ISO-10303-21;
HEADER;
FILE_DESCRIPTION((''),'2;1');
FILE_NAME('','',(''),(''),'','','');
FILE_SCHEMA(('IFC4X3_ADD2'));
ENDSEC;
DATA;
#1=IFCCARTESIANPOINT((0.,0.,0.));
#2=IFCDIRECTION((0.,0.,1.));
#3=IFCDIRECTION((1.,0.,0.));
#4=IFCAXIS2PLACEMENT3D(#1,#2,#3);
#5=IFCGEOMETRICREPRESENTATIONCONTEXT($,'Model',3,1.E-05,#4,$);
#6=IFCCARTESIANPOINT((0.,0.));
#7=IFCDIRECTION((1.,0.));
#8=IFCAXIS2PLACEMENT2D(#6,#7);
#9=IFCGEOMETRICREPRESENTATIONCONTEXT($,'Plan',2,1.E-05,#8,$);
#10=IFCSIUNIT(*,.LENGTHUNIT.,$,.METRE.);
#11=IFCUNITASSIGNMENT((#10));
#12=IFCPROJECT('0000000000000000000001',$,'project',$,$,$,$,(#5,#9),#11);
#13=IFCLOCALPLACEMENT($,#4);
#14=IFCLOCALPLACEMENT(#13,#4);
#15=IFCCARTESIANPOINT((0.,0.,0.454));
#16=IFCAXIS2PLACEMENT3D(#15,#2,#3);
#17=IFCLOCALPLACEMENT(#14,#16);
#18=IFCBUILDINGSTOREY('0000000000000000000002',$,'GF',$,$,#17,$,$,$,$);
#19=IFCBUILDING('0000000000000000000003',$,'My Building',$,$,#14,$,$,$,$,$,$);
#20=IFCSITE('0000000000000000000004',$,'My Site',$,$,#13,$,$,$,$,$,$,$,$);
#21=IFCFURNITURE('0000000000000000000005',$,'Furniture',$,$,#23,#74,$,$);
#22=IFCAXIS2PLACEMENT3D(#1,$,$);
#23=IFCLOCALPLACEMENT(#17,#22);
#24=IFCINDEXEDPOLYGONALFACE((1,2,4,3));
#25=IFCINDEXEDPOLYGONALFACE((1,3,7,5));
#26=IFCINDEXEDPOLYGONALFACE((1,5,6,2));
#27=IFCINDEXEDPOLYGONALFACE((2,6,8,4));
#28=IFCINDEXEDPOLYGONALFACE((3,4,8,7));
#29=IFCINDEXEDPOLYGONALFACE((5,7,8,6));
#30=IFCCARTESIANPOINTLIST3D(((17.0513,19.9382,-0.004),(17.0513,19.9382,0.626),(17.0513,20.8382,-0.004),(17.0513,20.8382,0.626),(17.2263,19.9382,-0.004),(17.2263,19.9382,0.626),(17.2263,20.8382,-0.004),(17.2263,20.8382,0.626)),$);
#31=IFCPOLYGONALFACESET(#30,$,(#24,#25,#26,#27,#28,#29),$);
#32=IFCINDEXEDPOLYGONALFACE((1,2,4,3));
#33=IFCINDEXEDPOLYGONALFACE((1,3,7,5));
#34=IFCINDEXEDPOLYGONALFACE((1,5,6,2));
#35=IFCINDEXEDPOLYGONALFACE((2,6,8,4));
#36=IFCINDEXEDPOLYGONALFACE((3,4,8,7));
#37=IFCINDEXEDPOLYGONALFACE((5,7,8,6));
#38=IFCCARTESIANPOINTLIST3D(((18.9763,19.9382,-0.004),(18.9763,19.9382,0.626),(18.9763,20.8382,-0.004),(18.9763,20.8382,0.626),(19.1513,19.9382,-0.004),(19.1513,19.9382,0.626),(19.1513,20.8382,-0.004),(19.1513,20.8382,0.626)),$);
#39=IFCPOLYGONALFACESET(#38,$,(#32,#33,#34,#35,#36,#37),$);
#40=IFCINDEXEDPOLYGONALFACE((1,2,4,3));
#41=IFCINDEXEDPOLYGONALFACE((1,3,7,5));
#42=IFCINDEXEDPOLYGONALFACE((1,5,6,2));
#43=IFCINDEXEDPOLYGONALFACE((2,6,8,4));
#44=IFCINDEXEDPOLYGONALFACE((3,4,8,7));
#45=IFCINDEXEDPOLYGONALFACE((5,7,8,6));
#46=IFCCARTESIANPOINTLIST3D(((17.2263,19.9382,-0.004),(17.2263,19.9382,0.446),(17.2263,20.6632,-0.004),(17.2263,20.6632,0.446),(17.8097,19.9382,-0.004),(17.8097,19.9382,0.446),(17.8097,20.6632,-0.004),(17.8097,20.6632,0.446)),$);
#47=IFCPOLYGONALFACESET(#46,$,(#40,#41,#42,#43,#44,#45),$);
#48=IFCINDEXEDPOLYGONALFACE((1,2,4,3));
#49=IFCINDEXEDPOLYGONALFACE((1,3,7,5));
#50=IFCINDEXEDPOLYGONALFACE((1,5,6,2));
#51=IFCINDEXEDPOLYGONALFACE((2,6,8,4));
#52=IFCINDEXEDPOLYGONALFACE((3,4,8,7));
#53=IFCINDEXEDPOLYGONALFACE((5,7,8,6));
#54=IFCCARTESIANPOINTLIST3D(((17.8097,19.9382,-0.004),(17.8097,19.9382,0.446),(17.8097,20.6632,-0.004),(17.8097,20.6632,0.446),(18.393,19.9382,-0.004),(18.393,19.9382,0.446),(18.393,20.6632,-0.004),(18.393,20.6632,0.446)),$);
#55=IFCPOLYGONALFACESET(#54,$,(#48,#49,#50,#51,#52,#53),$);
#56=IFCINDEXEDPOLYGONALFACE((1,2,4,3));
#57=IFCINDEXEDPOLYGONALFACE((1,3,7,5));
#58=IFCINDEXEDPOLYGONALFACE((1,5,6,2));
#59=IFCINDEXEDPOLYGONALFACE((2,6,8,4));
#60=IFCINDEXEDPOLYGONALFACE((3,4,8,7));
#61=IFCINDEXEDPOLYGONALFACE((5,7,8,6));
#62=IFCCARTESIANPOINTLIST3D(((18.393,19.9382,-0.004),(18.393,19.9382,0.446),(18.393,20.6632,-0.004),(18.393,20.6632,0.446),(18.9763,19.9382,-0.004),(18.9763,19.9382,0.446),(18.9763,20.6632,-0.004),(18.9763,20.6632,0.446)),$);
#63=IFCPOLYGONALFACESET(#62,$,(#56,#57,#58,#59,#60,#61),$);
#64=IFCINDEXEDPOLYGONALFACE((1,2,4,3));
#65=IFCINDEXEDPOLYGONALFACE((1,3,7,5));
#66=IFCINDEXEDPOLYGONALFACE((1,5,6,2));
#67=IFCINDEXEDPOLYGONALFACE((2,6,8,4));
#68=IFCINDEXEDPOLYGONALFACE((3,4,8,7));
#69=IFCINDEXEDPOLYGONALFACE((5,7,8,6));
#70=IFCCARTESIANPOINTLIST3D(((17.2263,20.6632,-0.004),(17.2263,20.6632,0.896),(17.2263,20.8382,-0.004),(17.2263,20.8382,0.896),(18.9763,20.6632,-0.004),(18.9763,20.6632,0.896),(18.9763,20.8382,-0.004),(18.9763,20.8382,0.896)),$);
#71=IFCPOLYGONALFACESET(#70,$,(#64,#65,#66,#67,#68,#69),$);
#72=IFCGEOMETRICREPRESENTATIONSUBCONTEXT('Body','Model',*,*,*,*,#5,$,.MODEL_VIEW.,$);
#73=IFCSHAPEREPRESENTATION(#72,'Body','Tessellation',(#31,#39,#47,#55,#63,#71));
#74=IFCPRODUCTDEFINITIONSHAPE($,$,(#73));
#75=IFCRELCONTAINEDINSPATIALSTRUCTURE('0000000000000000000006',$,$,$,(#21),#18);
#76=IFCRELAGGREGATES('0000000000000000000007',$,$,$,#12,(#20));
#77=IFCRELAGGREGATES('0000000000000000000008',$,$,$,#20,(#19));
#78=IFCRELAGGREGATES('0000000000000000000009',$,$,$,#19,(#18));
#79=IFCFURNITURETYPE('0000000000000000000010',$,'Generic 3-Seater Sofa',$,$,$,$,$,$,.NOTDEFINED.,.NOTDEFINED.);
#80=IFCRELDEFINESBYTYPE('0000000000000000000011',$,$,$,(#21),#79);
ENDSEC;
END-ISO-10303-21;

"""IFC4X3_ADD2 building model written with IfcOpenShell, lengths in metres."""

from ifc_helpers import new_model, entity, si_unit, frame, origin_with_axes, origin_2d_with_axis, place, context, subcontext, project, spatial, line, indexed_curve, outline, extrude, shape, source, transform, mapped, type_object, type_shapes, element, save


model = new_model("IFC4X3_ADD2")

# Units and contexts
model_context = context("Model", 3, precision=1e-05, world=origin_with_axes())
plan_context = context("Plan", 2, precision=1e-05, world=origin_2d_with_axis())
body_context_1 = subcontext(model_context, "Body", "Model", "MODEL_VIEW")
body_context_2 = subcontext(plan_context, "Body", "Plan", "PLAN_VIEW")
ifc_project = project(units=[si_unit("LENGTHUNIT", "METRE")], contexts=[model_context, plan_context])

# Site, building, storey
site_placement = place(None, origin_with_axes())
site = spatial("IfcSite", under=ifc_project, at=site_placement, Name="My Site")
building_placement = place(site_placement, origin_with_axes())
building = spatial("IfcBuilding", under=site, at=building_placement, Name="My Building")
storey_placement = place(building_placement, frame((0.0, 0.0, 0.454), z_axis=(0.0, 0.0, 1.0), x_axis=(1.0, 0.0, 0.0)))
storey = spatial("IfcBuildingStorey", under=building, at=storey_placement, Name="GF")

# Furniture
furniture_type_1 = type_object("IfcFurnitureType", Name="Generic 3-Seater Sofa", AssemblyPlace="NOTDEFINED", PredefinedType="NOTDEFINED")
shared_shape_1 = source(origin_with_axes(), body_context_1, "Body", "SweptSolid", [
    extrude(outline(indexed_curve([(0.0, 0.0), (0.175, 0.0), (0.175, 0.9), (0.0, 0.9)], segments=[line(4, 1), line(1, 2), line(2, 3), line(3, 4)], self_intersect=False)), frame((-1.05, -0.9, 0.0), z_axis=(0.0, 0.0, 1.0), x_axis=(1.0, 0.0, 0.0)), (0.0, 0.0, 1.0), 0.63),
    extrude(outline(indexed_curve([(0.0, 0.0), (0.175, 0.0), (0.175, 0.9), (0.0, 0.9)], segments=[line(1, 2, 3, 4, 1)])), frame((0.875, -0.9, 0.0), z_axis=(0.0, 0.0, 1.0), x_axis=(1.0, 0.0, 0.0)), (0.0, 0.0, 1.0), 0.63),
    extrude(outline(indexed_curve([(0.175, 0.0), (0.7583, 0.0), (0.7583, 0.725), (0.175, 0.725)], segments=[line(1, 2, 3, 4, 1)])), frame((-1.05, -0.9, 0.0), z_axis=(0.0, 0.0, 1.0), x_axis=(1.0, 0.0, 0.0)), (0.0, 0.0, 1.0), 0.45),
    extrude(outline(indexed_curve([(0.7583, 0.0), (1.3417, 0.0), (1.3417, 0.725), (0.7583, 0.725)], segments=[line(1, 2, 3, 4, 1)])), frame((-1.05, -0.9, 0.0), z_axis=(0.0, 0.0, 1.0), x_axis=(1.0, 0.0, 0.0)), (0.0, 0.0, 1.0), 0.45),
    extrude(outline(indexed_curve([(1.3417, 0.0), (1.925, 0.0), (1.925, 0.725), (1.3417, 0.725)], segments=[line(1, 2, 3, 4, 1)])), frame((-1.05, -0.9, 0.0), z_axis=(0.0, 0.0, 1.0), x_axis=(1.0, 0.0, 0.0)), (0.0, 0.0, 1.0), 0.45),
    extrude(outline(indexed_curve([(0.175, 0.725), (1.925, 0.725), (1.925, 0.9), (0.175, 0.9)], segments=[line(1, 2, 3, 4, 1)])), frame((-1.05, -0.9, 0.0), z_axis=(0.0, 0.0, 1.0), x_axis=(1.0, 0.0, 0.0)), (0.0, 0.0, 1.0), 0.9),
])
shared_shape_2 = source(origin_with_axes(), body_context_2, "Body", "Annotation2D", [
    entity("IfcGeometricCurveSet", [entity("IfcIndexedPolyCurve", entity("IfcCartesianPointList2D", [[0.2917, -0.175], [0.2917, -0.9], [0.875, -0.9], [0.875, -0.175], [-0.875, -0.175], [-0.875, 0.0], [0.875, 0.0], [1.05, 0.0], [1.05, -0.9], [0.875, -0.9], [0.875, 0.0], [0.875, -0.175], [0.2917, -0.175], [-0.2917, -0.175], [-0.2917, -0.9], [-0.875, -0.9], [-0.875, 0.0], [-1.05, 0.0], [-1.05, -0.9], [-0.875, -0.9], [-0.875, -0.175], [-0.2917, -0.175]])), entity("IfcIndexedPolyCurve", entity("IfcCartesianPointList2D", [[0.2917, -0.9], [-0.2917, -0.9]]))]),
])
type_shapes(furniture_type_1, [shared_shape_1, shared_shape_2])
furniture_1_placement = place(storey_placement, frame((18.1013, 20.8382, -0.004), z_axis=(0.0, 0.0, 1.0), x_axis=(1.0, 0.0, 0.0)))
element("IfcFurniture", 1, at=furniture_1_placement, inside=storey, type_object=furniture_type_1, Name="Furniture", shapes=[
    shape(body_context_1, "Body", "MappedRepresentation", [mapped(shared_shape_1, transform((0.0, 0.0, 0.0), x_axis=(1.0, 0.0, 0.0), y_axis=(0.0, 1.0, 0.0), z_axis=(0.0, 0.0, 1.0), scale=1.0))]),
    shape(body_context_2, "Body", "MappedRepresentation", [mapped(shared_shape_2, transform((0.0, 0.0, 0.0), x_axis=(1.0, 0.0, 0.0), y_axis=(0.0, 1.0, 0.0), z_axis=(0.0, 0.0, 1.0), scale=1.0))]),
])

save(model, "model.ifc")
